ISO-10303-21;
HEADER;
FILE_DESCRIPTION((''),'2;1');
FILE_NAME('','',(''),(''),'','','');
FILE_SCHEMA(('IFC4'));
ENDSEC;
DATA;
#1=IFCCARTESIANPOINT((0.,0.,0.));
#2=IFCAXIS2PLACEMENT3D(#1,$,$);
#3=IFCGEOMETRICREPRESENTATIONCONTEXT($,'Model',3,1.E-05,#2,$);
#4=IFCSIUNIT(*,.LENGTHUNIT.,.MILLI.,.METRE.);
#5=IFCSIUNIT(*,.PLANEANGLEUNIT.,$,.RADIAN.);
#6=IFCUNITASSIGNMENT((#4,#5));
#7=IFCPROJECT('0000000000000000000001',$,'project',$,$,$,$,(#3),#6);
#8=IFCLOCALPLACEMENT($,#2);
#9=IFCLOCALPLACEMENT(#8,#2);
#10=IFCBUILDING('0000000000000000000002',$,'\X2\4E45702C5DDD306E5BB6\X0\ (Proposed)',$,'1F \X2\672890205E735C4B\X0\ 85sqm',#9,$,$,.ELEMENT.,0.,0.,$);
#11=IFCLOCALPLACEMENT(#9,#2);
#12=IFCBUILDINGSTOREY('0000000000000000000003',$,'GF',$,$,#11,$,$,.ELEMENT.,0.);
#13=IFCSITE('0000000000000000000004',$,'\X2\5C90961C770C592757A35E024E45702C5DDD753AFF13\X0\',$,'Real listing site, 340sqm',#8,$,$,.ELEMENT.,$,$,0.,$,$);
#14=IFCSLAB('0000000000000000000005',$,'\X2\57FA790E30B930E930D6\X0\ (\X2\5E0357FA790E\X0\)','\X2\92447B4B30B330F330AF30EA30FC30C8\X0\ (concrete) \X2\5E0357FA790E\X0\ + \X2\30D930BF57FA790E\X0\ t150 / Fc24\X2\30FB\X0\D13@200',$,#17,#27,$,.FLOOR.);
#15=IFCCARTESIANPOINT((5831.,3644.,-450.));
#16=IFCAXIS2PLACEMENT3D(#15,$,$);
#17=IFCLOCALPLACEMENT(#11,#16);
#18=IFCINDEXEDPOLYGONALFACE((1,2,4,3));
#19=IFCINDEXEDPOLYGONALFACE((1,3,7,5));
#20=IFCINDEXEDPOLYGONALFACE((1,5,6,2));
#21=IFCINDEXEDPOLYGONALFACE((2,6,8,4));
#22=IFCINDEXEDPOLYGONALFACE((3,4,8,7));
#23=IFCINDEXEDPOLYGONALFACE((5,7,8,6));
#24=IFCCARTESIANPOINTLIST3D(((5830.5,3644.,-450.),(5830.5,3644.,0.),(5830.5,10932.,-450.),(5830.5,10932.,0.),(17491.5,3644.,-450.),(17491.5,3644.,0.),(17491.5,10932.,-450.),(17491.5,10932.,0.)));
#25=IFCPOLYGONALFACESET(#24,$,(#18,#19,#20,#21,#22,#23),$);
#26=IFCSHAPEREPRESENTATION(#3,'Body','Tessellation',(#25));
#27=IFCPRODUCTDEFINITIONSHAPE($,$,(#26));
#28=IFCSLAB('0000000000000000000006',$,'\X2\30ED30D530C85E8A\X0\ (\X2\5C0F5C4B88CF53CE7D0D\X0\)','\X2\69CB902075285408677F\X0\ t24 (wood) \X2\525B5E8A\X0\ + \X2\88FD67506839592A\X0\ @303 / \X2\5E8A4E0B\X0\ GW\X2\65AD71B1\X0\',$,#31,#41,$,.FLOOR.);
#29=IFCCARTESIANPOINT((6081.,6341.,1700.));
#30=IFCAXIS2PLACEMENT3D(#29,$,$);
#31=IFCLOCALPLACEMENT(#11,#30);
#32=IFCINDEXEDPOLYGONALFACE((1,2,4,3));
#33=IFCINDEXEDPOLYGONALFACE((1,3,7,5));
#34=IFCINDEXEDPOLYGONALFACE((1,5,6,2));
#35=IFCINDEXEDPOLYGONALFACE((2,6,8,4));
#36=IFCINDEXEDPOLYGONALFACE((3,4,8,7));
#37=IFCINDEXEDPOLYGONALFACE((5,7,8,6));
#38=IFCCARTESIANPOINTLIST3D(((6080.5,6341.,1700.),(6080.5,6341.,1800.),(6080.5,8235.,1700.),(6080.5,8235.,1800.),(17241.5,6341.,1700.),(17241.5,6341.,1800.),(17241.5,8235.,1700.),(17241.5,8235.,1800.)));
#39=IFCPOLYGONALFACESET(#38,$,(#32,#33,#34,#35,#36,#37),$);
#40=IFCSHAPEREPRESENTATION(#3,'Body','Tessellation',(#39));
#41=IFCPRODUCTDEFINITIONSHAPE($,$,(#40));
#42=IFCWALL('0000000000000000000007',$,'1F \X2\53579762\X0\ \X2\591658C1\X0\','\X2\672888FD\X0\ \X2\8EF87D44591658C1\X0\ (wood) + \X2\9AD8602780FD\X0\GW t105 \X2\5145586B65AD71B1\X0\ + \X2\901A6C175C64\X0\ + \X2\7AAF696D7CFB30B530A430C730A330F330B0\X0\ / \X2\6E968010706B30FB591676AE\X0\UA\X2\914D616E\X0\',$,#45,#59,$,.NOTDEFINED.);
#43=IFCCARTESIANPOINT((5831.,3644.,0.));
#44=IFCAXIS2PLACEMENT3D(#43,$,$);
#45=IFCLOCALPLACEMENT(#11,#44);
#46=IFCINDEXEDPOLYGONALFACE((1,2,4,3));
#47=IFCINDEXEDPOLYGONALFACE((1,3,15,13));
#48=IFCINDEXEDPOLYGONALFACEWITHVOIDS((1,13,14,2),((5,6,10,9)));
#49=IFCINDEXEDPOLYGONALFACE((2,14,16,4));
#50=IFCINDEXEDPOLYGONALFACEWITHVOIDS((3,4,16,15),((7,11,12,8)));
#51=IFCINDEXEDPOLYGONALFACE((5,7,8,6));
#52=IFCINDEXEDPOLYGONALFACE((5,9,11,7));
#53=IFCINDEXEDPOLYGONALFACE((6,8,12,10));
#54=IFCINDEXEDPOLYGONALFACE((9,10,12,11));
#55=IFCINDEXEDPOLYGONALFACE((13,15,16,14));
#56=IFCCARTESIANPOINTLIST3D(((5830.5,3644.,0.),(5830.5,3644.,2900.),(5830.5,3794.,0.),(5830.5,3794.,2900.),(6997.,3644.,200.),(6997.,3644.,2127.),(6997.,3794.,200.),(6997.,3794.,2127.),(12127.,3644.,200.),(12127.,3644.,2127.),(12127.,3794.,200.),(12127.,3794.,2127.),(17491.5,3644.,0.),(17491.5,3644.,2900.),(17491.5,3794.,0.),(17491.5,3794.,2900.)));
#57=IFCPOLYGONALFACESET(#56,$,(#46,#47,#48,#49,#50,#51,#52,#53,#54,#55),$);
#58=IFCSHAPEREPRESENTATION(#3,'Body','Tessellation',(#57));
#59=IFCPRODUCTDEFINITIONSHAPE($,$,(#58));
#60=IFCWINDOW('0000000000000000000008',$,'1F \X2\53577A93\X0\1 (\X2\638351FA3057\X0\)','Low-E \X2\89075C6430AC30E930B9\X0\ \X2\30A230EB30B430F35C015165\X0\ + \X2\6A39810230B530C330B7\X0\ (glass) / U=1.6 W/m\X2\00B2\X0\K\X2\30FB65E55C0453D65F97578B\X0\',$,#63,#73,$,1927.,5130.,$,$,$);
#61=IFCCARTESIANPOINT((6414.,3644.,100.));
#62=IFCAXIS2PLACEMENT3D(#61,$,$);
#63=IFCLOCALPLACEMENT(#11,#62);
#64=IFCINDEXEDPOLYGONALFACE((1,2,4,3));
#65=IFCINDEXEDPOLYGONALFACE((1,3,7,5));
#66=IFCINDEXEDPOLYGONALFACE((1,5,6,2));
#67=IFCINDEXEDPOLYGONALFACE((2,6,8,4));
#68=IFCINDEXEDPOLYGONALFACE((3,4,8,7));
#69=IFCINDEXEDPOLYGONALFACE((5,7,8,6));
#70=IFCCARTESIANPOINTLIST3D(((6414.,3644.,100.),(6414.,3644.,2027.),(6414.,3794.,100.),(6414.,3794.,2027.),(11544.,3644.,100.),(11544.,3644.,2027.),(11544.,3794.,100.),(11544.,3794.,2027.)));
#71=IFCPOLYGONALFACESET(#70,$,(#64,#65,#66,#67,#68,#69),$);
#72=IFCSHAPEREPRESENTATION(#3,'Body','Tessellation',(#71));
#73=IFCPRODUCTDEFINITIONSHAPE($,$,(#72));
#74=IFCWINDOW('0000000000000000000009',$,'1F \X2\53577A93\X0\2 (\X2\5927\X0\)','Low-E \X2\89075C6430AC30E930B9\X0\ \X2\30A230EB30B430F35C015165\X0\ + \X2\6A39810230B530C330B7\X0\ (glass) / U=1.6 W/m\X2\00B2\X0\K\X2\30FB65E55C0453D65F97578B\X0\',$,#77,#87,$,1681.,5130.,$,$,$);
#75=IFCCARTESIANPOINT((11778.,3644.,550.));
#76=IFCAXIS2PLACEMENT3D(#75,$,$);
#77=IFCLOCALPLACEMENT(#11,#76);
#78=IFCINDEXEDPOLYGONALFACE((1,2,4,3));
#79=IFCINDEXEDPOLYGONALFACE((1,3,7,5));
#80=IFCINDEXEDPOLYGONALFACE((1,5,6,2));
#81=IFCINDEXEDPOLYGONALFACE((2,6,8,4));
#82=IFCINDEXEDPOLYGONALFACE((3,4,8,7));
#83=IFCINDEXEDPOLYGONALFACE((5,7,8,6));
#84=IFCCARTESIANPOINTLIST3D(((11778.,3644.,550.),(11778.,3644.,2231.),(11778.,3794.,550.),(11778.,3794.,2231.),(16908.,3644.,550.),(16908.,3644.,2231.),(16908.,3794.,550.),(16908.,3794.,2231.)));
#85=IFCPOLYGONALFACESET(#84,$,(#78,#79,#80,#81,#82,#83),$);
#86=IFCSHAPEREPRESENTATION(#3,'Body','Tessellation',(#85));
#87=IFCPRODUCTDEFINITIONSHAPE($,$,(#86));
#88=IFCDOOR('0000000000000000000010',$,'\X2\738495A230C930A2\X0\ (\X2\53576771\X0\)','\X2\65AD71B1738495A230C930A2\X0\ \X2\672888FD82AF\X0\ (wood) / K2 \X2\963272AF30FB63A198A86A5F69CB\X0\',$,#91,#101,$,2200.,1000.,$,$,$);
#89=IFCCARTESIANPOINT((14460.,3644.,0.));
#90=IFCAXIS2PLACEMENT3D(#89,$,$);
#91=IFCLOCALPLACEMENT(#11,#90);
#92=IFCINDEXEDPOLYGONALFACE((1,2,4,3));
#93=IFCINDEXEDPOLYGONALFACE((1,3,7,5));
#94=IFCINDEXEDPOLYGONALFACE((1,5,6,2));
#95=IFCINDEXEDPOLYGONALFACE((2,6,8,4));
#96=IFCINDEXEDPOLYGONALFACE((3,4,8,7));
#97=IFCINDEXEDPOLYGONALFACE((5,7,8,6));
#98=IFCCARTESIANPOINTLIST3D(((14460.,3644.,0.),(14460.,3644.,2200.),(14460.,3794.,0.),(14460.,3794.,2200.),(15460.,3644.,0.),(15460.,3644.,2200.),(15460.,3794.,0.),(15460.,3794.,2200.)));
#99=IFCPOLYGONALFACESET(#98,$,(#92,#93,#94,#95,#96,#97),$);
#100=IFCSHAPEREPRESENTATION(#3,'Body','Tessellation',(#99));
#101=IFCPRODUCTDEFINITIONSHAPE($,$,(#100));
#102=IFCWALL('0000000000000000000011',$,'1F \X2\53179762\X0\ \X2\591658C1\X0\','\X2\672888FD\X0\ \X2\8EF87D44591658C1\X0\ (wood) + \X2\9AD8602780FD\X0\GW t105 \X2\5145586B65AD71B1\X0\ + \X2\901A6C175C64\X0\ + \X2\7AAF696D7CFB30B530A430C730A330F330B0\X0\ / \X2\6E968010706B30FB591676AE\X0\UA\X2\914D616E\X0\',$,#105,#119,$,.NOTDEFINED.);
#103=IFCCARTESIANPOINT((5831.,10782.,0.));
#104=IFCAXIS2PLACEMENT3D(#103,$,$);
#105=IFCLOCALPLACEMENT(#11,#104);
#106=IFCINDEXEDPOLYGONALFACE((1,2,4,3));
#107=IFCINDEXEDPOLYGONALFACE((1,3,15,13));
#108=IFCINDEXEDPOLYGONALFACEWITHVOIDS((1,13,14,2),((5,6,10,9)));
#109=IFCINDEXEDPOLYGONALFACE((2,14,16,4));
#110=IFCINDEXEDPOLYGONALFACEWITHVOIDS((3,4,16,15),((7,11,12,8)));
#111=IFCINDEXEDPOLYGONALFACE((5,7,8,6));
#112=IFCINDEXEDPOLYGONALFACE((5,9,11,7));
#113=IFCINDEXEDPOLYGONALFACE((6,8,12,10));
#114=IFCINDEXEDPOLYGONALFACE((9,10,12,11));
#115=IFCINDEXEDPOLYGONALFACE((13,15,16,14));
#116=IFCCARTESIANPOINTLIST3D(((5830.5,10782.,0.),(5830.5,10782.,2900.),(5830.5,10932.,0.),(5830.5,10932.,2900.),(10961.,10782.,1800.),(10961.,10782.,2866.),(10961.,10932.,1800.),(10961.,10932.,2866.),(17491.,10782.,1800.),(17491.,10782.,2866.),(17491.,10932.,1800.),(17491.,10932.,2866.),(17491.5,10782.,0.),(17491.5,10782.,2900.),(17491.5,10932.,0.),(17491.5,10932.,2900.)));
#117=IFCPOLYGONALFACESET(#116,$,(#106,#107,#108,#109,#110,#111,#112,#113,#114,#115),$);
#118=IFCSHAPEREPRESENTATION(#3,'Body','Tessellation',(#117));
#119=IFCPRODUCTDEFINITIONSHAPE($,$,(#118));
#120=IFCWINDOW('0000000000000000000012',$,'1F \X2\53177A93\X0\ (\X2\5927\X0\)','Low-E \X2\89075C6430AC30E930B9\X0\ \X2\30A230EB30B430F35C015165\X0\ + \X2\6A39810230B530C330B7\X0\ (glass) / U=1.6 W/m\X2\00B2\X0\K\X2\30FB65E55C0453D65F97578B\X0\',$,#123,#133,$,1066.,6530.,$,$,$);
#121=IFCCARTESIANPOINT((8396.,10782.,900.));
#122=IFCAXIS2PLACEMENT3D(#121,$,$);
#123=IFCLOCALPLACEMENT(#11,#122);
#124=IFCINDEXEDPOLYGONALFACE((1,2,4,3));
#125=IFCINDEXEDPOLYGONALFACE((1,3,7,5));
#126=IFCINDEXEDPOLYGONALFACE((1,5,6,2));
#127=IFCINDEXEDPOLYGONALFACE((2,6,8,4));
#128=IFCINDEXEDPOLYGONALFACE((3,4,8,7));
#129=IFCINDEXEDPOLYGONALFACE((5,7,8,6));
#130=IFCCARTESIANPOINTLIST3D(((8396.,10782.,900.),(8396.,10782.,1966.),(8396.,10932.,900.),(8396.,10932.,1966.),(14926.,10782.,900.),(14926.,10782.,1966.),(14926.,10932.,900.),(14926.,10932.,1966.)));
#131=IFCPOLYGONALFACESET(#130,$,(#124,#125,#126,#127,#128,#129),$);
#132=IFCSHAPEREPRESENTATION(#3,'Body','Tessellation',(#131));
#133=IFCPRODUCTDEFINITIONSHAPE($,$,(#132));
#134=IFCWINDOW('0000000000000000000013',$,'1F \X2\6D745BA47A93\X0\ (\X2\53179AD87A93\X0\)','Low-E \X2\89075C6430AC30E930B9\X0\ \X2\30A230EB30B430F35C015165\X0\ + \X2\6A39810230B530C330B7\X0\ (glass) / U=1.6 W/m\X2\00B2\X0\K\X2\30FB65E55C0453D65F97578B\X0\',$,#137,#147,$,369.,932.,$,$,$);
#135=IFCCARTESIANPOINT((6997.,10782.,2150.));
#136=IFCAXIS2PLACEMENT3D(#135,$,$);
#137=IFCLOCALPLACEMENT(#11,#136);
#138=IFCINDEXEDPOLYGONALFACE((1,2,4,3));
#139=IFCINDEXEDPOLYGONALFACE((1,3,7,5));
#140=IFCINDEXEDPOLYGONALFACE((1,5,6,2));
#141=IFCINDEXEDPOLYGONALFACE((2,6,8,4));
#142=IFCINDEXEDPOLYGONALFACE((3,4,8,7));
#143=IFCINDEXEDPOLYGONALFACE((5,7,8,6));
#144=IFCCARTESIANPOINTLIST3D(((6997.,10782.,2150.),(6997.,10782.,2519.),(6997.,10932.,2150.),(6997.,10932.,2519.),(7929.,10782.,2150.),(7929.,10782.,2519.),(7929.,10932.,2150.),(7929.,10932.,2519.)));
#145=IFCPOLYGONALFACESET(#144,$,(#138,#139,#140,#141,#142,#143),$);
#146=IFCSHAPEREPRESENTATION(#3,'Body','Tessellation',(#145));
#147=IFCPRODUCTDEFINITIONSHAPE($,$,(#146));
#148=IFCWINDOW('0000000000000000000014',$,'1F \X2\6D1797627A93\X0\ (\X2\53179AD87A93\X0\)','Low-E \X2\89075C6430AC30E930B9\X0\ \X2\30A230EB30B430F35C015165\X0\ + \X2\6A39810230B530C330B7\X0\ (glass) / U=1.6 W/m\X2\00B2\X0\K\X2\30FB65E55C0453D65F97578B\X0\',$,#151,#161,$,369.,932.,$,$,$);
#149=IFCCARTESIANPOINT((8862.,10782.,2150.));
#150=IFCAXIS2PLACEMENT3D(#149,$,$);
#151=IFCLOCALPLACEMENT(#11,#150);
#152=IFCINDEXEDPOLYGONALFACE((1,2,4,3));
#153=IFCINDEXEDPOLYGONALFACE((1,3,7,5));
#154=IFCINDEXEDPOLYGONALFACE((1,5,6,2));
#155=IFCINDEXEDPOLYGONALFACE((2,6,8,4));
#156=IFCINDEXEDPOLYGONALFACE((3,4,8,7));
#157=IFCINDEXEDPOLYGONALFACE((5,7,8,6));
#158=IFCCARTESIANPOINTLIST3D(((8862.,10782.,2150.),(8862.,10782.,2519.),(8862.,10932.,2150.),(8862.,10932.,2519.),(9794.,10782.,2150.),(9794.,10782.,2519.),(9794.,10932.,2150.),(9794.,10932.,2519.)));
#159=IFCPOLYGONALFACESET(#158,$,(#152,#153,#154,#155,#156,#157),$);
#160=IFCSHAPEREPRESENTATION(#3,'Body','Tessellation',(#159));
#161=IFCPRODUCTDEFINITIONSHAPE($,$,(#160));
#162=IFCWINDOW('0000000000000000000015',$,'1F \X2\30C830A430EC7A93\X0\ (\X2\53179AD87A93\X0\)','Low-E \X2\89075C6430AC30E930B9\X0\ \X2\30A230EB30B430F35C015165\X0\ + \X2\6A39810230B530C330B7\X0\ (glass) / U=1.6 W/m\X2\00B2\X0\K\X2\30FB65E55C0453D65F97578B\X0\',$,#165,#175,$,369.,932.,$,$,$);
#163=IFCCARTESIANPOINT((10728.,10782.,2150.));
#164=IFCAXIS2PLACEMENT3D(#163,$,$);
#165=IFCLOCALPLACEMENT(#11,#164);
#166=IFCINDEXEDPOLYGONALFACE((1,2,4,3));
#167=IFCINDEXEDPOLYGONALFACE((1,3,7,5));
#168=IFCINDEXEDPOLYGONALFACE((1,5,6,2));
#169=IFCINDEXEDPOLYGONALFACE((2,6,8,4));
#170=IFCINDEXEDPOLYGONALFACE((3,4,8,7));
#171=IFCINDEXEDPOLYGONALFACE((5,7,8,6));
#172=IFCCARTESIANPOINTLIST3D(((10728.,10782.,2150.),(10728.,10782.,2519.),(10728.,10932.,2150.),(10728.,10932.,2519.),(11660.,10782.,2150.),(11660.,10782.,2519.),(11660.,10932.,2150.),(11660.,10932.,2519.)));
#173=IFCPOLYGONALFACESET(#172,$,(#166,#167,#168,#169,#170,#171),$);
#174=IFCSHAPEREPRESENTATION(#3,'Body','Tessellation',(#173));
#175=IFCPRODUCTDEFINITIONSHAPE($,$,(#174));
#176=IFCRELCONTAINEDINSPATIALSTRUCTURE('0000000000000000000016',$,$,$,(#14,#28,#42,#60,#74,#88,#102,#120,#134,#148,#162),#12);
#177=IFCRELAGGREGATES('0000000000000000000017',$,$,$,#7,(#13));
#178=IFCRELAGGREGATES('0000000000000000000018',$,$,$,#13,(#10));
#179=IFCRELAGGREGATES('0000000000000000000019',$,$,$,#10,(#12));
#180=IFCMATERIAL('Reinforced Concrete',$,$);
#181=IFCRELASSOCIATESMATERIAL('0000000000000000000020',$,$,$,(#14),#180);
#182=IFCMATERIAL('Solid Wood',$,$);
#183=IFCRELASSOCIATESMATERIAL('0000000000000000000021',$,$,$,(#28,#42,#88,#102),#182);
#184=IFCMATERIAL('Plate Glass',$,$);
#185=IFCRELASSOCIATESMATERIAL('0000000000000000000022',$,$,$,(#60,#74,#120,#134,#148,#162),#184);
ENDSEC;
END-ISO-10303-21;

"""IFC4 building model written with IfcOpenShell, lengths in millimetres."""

from ifc_helpers import new_model, si_unit, frame, frame_2d, origin, place, context, project, spatial, rectangle, extrude, material, element, fill, save


model = new_model("IFC4")

# Units and contexts
model_context = context("Model", 3, precision=1e-05, world=origin())
ifc_project = project(units=[si_unit("LENGTHUNIT", "METRE", prefix="MILLI"), si_unit("PLANEANGLEUNIT", "RADIAN")], contexts=[model_context])

# Site, building, storey
site_placement = place(None, origin())
site = spatial("IfcSite", under=ifc_project, at=site_placement, Name="岐阜県大垣市久瀬川町３", ObjectType="Real listing site, 340sqm", CompositionType="ELEMENT", RefElevation=0.0)
building_placement = place(site_placement, origin())
building = spatial("IfcBuilding", under=site, at=building_placement, Name="久瀬川の家 (Proposed)", ObjectType="1F 木造平屋 85sqm", CompositionType="ELEMENT", ElevationOfRefHeight=0.0, ElevationOfTerrain=0.0)
storey_placement = place(building_placement, origin())
storey = spatial("IfcBuildingStorey", under=building, at=storey_placement, Name="GF", CompositionType="ELEMENT", Elevation=0.0)

# Slabs
ifc_material_1 = material(Name="Reinforced Concrete")
slab_1_placement = place(storey_placement, frame((5831.0, 3644.0, -450.0)))
element("IfcSlab", 1, at=slab_1_placement, inside=storey, material=ifc_material_1, Name="基礎スラブ (布基礎)", Description="鉄筋コンクリート (concrete) 布基礎 + ベタ基礎 t150 / Fc24・D13@200", PredefinedType="FLOOR", context=model_context, shape_type="SweptSolid", body=[
    extrude(rectangle(XDim=11661.0, YDim=7288.0, at=frame_2d((5830.0, 3644.0))), frame((5831.0, 3644.0, -450.0)), (0.0, 0.0, 1.0), 450.0),
])
ifc_material_2 = material(Name="Solid Wood")
slab_2_placement = place(storey_placement, frame((6081.0, 6341.0, 1700.0)))
element("IfcSlab", 2, at=slab_2_placement, inside=storey, material=ifc_material_2, Name="ロフト床 (小屋裏収納)", Description="構造用合板 t24 (wood) 剛床 + 製材根太 @303 / 床下 GW断熱", PredefinedType="FLOOR", context=model_context, shape_type="SweptSolid", body=[
    extrude(rectangle(XDim=11161.0, YDim=1894.0, at=frame_2d((5580.0, 947.0))), frame((6081.0, 6341.0, 1700.0)), (0.0, 0.0, 1.0), 100.0),
])

# Wall, openings, windows, door
wall_1_placement = place(storey_placement, frame((5831.0, 3644.0, 0.0)))
wall_1 = element("IfcWall", 3, at=wall_1_placement, inside=storey, material=ifc_material_2, Name="1F 南面 外壁", Description="木製 軸組外壁 (wood) + 高性能GW t105 充填断熱 + 通気層 + 窯業系サイディング / 準耐火・外皮UA配慮", PredefinedType="NOTDEFINED", context=model_context, shape_type="SweptSolid", body=[
    extrude(rectangle(XDim=11661.0, YDim=150.0, at=frame_2d((5830.0, 75.0))), frame((5831.0, 3644.0, 0.0)), (0.0, 0.0, 1.0), 2900.0),
])
opening_1_placement = place(storey_placement, frame((6414.0, 3644.0, 100.0)))
opening_1 = element("IfcOpeningElement", 4, at=opening_1_placement, cuts=wall_1, PredefinedType="NOTDEFINED", context=model_context, shape_type="SweptSolid", body=[
    extrude(rectangle(XDim=5130.0, YDim=150.0, at=frame_2d((2565.0, 75.0))), frame((6414.0, 3644.0, 100.0)), (0.0, 0.0, 1.0), 1927.0),
])
opening_2_placement = place(storey_placement, frame((11778.0, 3644.0, 550.0)))
opening_2 = element("IfcOpeningElement", 5, at=opening_2_placement, cuts=wall_1, PredefinedType="NOTDEFINED", context=model_context, shape_type="SweptSolid", body=[
    extrude(rectangle(XDim=5130.0, YDim=150.0, at=frame_2d((2565.0, 75.0))), frame((11778.0, 3644.0, 550.0)), (0.0, 0.0, 1.0), 1681.0),
])
opening_3_placement = place(storey_placement, frame((14460.0, 3644.0, 0.0)))
opening_3 = element("IfcOpeningElement", 6, at=opening_3_placement, cuts=wall_1, PredefinedType="NOTDEFINED", context=model_context, shape_type="SweptSolid", body=[
    extrude(rectangle(XDim=1000.0, YDim=150.0, at=frame_2d((500.0, 75.0))), frame((14460.0, 3644.0, 0.0)), (0.0, 0.0, 1.0), 2200.0),
])
ifc_material_3 = material(Name="Plate Glass")
window_1_placement = place(storey_placement, frame((6414.0, 3644.0, 100.0)))
window_1 = element("IfcWindow", 7, at=window_1_placement, inside=storey, material=ifc_material_3, Name="1F 南窓1 (掃出し)", Description="Low-E 複層ガラス アルゴン封入 + 樹脂サッシ (glass) / U=1.6 W/m²K・日射取得型", OverallHeight=1927.0, OverallWidth=5130.0, context=model_context, shape_type="SweptSolid", body=[
    extrude(rectangle(XDim=5130.0, YDim=150.0, at=frame_2d((2565.0, 75.0))), frame((6414.0, 3644.0, 100.0)), (0.0, 0.0, 1.0), 1927.0),
])
fill(opening_1, window_1)
window_2_placement = place(storey_placement, frame((11778.0, 3644.0, 550.0)))
window_2 = element("IfcWindow", 8, at=window_2_placement, inside=storey, material=ifc_material_3, Name="1F 南窓2 (大)", Description="Low-E 複層ガラス アルゴン封入 + 樹脂サッシ (glass) / U=1.6 W/m²K・日射取得型", OverallHeight=1681.0, OverallWidth=5130.0, context=model_context, shape_type="SweptSolid", body=[
    extrude(rectangle(XDim=5130.0, YDim=150.0, at=frame_2d((2565.0, 75.0))), frame((11778.0, 3644.0, 550.0)), (0.0, 0.0, 1.0), 1681.0),
])
fill(opening_2, window_2)
door_1_placement = place(storey_placement, frame((14460.0, 3644.0, 0.0)))
door_1 = element("IfcDoor", 9, at=door_1_placement, inside=storey, material=ifc_material_2, Name="玄関ドア (南東)", Description="断熱玄関ドア 木製芯 (wood) / K2 防犯・採風機構", OverallHeight=2200.0, OverallWidth=1000.0, context=model_context, shape_type="SweptSolid", body=[
    extrude(rectangle(XDim=1000.0, YDim=150.0, at=frame_2d((500.0, 75.0))), frame((14460.0, 3644.0, 0.0)), (0.0, 0.0, 1.0), 2200.0),
])
fill(opening_3, door_1)

# Wall, openings, windows
wall_2_placement = place(storey_placement, frame((5831.0, 10782.0, 0.0)))
wall_2 = element("IfcWall", 10, at=wall_2_placement, inside=storey, material=ifc_material_2, Name="1F 北面 外壁", Description="木製 軸組外壁 (wood) + 高性能GW t105 充填断熱 + 通気層 + 窯業系サイディング / 準耐火・外皮UA配慮", PredefinedType="NOTDEFINED", context=model_context, shape_type="SweptSolid", body=[
    extrude(rectangle(XDim=11661.0, YDim=150.0, at=frame_2d((5830.0, 75.0))), frame((5831.0, 10782.0, 0.0)), (0.0, 0.0, 1.0), 2900.0),
])
opening_4_placement = place(storey_placement, frame((8396.0, 10782.0, 900.0)))
opening_4 = element("IfcOpeningElement", 11, at=opening_4_placement, cuts=wall_2, PredefinedType="NOTDEFINED", context=model_context, shape_type="SweptSolid", body=[
    extrude(rectangle(XDim=6530.0, YDim=150.0, at=frame_2d((3265.0, 75.0))), frame((8396.0, 10782.0, 900.0)), (0.0, 0.0, 1.0), 1066.0),
])
opening_5_placement = place(storey_placement, frame((6997.0, 10782.0, 2150.0)))
opening_5 = element("IfcOpeningElement", 12, at=opening_5_placement, cuts=wall_2, PredefinedType="NOTDEFINED", context=model_context, shape_type="SweptSolid", body=[
    extrude(rectangle(XDim=932.0, YDim=150.0, at=frame_2d((466.0, 75.0))), frame((6997.0, 10782.0, 2150.0)), (0.0, 0.0, 1.0), 369.0),
])
opening_6_placement = place(storey_placement, frame((8862.0, 10782.0, 2150.0)))
opening_6 = element("IfcOpeningElement", 13, at=opening_6_placement, cuts=wall_2, PredefinedType="NOTDEFINED", context=model_context, shape_type="SweptSolid", body=[
    extrude(rectangle(XDim=932.0, YDim=150.0, at=frame_2d((466.0, 75.0))), frame((8862.0, 10782.0, 2150.0)), (0.0, 0.0, 1.0), 369.0),
])
opening_7_placement = place(storey_placement, frame((10728.0, 10782.0, 2150.0)))
opening_7 = element("IfcOpeningElement", 14, at=opening_7_placement, cuts=wall_2, PredefinedType="NOTDEFINED", context=model_context, shape_type="SweptSolid", body=[
    extrude(rectangle(XDim=932.0, YDim=150.0, at=frame_2d((466.0, 75.0))), frame((10728.0, 10782.0, 2150.0)), (0.0, 0.0, 1.0), 369.0),
])
window_3_placement = place(storey_placement, frame((8396.0, 10782.0, 900.0)))
window_3 = element("IfcWindow", 15, at=window_3_placement, inside=storey, material=ifc_material_3, Name="1F 北窓 (大)", Description="Low-E 複層ガラス アルゴン封入 + 樹脂サッシ (glass) / U=1.6 W/m²K・日射取得型", OverallHeight=1066.0, OverallWidth=6530.0, context=model_context, shape_type="SweptSolid", body=[
    extrude(rectangle(XDim=6530.0, YDim=150.0, at=frame_2d((3265.0, 75.0))), frame((8396.0, 10782.0, 900.0)), (0.0, 0.0, 1.0), 1066.0),
])
fill(opening_4, window_3)
window_4_placement = place(storey_placement, frame((6997.0, 10782.0, 2150.0)))
window_4 = element("IfcWindow", 16, at=window_4_placement, inside=storey, material=ifc_material_3, Name="1F 浴室窓 (北高窓)", Description="Low-E 複層ガラス アルゴン封入 + 樹脂サッシ (glass) / U=1.6 W/m²K・日射取得型", OverallHeight=369.0, OverallWidth=932.0, context=model_context, shape_type="SweptSolid", body=[
    extrude(rectangle(XDim=932.0, YDim=150.0, at=frame_2d((466.0, 75.0))), frame((6997.0, 10782.0, 2150.0)), (0.0, 0.0, 1.0), 369.0),
])
fill(opening_5, window_4)
window_5_placement = place(storey_placement, frame((8862.0, 10782.0, 2150.0)))
window_5 = element("IfcWindow", 17, at=window_5_placement, inside=storey, material=ifc_material_3, Name="1F 洗面窓 (北高窓)", Description="Low-E 複層ガラス アルゴン封入 + 樹脂サッシ (glass) / U=1.6 W/m²K・日射取得型", OverallHeight=369.0, OverallWidth=932.0, context=model_context, shape_type="SweptSolid", body=[
    extrude(rectangle(XDim=932.0, YDim=150.0, at=frame_2d((466.0, 75.0))), frame((8862.0, 10782.0, 2150.0)), (0.0, 0.0, 1.0), 369.0),
])
fill(opening_6, window_5)
window_6_placement = place(storey_placement, frame((10728.0, 10782.0, 2150.0)))
window_6 = element("IfcWindow", 18, at=window_6_placement, inside=storey, material=ifc_material_3, Name="1F トイレ窓 (北高窓)", Description="Low-E 複層ガラス アルゴン封入 + 樹脂サッシ (glass) / U=1.6 W/m²K・日射取得型", OverallHeight=369.0, OverallWidth=932.0, context=model_context, shape_type="SweptSolid", body=[
    extrude(rectangle(XDim=932.0, YDim=150.0, at=frame_2d((466.0, 75.0))), frame((10728.0, 10782.0, 2150.0)), (0.0, 0.0, 1.0), 369.0),
])
fill(opening_7, window_6)

save(model, "model.ifc")
